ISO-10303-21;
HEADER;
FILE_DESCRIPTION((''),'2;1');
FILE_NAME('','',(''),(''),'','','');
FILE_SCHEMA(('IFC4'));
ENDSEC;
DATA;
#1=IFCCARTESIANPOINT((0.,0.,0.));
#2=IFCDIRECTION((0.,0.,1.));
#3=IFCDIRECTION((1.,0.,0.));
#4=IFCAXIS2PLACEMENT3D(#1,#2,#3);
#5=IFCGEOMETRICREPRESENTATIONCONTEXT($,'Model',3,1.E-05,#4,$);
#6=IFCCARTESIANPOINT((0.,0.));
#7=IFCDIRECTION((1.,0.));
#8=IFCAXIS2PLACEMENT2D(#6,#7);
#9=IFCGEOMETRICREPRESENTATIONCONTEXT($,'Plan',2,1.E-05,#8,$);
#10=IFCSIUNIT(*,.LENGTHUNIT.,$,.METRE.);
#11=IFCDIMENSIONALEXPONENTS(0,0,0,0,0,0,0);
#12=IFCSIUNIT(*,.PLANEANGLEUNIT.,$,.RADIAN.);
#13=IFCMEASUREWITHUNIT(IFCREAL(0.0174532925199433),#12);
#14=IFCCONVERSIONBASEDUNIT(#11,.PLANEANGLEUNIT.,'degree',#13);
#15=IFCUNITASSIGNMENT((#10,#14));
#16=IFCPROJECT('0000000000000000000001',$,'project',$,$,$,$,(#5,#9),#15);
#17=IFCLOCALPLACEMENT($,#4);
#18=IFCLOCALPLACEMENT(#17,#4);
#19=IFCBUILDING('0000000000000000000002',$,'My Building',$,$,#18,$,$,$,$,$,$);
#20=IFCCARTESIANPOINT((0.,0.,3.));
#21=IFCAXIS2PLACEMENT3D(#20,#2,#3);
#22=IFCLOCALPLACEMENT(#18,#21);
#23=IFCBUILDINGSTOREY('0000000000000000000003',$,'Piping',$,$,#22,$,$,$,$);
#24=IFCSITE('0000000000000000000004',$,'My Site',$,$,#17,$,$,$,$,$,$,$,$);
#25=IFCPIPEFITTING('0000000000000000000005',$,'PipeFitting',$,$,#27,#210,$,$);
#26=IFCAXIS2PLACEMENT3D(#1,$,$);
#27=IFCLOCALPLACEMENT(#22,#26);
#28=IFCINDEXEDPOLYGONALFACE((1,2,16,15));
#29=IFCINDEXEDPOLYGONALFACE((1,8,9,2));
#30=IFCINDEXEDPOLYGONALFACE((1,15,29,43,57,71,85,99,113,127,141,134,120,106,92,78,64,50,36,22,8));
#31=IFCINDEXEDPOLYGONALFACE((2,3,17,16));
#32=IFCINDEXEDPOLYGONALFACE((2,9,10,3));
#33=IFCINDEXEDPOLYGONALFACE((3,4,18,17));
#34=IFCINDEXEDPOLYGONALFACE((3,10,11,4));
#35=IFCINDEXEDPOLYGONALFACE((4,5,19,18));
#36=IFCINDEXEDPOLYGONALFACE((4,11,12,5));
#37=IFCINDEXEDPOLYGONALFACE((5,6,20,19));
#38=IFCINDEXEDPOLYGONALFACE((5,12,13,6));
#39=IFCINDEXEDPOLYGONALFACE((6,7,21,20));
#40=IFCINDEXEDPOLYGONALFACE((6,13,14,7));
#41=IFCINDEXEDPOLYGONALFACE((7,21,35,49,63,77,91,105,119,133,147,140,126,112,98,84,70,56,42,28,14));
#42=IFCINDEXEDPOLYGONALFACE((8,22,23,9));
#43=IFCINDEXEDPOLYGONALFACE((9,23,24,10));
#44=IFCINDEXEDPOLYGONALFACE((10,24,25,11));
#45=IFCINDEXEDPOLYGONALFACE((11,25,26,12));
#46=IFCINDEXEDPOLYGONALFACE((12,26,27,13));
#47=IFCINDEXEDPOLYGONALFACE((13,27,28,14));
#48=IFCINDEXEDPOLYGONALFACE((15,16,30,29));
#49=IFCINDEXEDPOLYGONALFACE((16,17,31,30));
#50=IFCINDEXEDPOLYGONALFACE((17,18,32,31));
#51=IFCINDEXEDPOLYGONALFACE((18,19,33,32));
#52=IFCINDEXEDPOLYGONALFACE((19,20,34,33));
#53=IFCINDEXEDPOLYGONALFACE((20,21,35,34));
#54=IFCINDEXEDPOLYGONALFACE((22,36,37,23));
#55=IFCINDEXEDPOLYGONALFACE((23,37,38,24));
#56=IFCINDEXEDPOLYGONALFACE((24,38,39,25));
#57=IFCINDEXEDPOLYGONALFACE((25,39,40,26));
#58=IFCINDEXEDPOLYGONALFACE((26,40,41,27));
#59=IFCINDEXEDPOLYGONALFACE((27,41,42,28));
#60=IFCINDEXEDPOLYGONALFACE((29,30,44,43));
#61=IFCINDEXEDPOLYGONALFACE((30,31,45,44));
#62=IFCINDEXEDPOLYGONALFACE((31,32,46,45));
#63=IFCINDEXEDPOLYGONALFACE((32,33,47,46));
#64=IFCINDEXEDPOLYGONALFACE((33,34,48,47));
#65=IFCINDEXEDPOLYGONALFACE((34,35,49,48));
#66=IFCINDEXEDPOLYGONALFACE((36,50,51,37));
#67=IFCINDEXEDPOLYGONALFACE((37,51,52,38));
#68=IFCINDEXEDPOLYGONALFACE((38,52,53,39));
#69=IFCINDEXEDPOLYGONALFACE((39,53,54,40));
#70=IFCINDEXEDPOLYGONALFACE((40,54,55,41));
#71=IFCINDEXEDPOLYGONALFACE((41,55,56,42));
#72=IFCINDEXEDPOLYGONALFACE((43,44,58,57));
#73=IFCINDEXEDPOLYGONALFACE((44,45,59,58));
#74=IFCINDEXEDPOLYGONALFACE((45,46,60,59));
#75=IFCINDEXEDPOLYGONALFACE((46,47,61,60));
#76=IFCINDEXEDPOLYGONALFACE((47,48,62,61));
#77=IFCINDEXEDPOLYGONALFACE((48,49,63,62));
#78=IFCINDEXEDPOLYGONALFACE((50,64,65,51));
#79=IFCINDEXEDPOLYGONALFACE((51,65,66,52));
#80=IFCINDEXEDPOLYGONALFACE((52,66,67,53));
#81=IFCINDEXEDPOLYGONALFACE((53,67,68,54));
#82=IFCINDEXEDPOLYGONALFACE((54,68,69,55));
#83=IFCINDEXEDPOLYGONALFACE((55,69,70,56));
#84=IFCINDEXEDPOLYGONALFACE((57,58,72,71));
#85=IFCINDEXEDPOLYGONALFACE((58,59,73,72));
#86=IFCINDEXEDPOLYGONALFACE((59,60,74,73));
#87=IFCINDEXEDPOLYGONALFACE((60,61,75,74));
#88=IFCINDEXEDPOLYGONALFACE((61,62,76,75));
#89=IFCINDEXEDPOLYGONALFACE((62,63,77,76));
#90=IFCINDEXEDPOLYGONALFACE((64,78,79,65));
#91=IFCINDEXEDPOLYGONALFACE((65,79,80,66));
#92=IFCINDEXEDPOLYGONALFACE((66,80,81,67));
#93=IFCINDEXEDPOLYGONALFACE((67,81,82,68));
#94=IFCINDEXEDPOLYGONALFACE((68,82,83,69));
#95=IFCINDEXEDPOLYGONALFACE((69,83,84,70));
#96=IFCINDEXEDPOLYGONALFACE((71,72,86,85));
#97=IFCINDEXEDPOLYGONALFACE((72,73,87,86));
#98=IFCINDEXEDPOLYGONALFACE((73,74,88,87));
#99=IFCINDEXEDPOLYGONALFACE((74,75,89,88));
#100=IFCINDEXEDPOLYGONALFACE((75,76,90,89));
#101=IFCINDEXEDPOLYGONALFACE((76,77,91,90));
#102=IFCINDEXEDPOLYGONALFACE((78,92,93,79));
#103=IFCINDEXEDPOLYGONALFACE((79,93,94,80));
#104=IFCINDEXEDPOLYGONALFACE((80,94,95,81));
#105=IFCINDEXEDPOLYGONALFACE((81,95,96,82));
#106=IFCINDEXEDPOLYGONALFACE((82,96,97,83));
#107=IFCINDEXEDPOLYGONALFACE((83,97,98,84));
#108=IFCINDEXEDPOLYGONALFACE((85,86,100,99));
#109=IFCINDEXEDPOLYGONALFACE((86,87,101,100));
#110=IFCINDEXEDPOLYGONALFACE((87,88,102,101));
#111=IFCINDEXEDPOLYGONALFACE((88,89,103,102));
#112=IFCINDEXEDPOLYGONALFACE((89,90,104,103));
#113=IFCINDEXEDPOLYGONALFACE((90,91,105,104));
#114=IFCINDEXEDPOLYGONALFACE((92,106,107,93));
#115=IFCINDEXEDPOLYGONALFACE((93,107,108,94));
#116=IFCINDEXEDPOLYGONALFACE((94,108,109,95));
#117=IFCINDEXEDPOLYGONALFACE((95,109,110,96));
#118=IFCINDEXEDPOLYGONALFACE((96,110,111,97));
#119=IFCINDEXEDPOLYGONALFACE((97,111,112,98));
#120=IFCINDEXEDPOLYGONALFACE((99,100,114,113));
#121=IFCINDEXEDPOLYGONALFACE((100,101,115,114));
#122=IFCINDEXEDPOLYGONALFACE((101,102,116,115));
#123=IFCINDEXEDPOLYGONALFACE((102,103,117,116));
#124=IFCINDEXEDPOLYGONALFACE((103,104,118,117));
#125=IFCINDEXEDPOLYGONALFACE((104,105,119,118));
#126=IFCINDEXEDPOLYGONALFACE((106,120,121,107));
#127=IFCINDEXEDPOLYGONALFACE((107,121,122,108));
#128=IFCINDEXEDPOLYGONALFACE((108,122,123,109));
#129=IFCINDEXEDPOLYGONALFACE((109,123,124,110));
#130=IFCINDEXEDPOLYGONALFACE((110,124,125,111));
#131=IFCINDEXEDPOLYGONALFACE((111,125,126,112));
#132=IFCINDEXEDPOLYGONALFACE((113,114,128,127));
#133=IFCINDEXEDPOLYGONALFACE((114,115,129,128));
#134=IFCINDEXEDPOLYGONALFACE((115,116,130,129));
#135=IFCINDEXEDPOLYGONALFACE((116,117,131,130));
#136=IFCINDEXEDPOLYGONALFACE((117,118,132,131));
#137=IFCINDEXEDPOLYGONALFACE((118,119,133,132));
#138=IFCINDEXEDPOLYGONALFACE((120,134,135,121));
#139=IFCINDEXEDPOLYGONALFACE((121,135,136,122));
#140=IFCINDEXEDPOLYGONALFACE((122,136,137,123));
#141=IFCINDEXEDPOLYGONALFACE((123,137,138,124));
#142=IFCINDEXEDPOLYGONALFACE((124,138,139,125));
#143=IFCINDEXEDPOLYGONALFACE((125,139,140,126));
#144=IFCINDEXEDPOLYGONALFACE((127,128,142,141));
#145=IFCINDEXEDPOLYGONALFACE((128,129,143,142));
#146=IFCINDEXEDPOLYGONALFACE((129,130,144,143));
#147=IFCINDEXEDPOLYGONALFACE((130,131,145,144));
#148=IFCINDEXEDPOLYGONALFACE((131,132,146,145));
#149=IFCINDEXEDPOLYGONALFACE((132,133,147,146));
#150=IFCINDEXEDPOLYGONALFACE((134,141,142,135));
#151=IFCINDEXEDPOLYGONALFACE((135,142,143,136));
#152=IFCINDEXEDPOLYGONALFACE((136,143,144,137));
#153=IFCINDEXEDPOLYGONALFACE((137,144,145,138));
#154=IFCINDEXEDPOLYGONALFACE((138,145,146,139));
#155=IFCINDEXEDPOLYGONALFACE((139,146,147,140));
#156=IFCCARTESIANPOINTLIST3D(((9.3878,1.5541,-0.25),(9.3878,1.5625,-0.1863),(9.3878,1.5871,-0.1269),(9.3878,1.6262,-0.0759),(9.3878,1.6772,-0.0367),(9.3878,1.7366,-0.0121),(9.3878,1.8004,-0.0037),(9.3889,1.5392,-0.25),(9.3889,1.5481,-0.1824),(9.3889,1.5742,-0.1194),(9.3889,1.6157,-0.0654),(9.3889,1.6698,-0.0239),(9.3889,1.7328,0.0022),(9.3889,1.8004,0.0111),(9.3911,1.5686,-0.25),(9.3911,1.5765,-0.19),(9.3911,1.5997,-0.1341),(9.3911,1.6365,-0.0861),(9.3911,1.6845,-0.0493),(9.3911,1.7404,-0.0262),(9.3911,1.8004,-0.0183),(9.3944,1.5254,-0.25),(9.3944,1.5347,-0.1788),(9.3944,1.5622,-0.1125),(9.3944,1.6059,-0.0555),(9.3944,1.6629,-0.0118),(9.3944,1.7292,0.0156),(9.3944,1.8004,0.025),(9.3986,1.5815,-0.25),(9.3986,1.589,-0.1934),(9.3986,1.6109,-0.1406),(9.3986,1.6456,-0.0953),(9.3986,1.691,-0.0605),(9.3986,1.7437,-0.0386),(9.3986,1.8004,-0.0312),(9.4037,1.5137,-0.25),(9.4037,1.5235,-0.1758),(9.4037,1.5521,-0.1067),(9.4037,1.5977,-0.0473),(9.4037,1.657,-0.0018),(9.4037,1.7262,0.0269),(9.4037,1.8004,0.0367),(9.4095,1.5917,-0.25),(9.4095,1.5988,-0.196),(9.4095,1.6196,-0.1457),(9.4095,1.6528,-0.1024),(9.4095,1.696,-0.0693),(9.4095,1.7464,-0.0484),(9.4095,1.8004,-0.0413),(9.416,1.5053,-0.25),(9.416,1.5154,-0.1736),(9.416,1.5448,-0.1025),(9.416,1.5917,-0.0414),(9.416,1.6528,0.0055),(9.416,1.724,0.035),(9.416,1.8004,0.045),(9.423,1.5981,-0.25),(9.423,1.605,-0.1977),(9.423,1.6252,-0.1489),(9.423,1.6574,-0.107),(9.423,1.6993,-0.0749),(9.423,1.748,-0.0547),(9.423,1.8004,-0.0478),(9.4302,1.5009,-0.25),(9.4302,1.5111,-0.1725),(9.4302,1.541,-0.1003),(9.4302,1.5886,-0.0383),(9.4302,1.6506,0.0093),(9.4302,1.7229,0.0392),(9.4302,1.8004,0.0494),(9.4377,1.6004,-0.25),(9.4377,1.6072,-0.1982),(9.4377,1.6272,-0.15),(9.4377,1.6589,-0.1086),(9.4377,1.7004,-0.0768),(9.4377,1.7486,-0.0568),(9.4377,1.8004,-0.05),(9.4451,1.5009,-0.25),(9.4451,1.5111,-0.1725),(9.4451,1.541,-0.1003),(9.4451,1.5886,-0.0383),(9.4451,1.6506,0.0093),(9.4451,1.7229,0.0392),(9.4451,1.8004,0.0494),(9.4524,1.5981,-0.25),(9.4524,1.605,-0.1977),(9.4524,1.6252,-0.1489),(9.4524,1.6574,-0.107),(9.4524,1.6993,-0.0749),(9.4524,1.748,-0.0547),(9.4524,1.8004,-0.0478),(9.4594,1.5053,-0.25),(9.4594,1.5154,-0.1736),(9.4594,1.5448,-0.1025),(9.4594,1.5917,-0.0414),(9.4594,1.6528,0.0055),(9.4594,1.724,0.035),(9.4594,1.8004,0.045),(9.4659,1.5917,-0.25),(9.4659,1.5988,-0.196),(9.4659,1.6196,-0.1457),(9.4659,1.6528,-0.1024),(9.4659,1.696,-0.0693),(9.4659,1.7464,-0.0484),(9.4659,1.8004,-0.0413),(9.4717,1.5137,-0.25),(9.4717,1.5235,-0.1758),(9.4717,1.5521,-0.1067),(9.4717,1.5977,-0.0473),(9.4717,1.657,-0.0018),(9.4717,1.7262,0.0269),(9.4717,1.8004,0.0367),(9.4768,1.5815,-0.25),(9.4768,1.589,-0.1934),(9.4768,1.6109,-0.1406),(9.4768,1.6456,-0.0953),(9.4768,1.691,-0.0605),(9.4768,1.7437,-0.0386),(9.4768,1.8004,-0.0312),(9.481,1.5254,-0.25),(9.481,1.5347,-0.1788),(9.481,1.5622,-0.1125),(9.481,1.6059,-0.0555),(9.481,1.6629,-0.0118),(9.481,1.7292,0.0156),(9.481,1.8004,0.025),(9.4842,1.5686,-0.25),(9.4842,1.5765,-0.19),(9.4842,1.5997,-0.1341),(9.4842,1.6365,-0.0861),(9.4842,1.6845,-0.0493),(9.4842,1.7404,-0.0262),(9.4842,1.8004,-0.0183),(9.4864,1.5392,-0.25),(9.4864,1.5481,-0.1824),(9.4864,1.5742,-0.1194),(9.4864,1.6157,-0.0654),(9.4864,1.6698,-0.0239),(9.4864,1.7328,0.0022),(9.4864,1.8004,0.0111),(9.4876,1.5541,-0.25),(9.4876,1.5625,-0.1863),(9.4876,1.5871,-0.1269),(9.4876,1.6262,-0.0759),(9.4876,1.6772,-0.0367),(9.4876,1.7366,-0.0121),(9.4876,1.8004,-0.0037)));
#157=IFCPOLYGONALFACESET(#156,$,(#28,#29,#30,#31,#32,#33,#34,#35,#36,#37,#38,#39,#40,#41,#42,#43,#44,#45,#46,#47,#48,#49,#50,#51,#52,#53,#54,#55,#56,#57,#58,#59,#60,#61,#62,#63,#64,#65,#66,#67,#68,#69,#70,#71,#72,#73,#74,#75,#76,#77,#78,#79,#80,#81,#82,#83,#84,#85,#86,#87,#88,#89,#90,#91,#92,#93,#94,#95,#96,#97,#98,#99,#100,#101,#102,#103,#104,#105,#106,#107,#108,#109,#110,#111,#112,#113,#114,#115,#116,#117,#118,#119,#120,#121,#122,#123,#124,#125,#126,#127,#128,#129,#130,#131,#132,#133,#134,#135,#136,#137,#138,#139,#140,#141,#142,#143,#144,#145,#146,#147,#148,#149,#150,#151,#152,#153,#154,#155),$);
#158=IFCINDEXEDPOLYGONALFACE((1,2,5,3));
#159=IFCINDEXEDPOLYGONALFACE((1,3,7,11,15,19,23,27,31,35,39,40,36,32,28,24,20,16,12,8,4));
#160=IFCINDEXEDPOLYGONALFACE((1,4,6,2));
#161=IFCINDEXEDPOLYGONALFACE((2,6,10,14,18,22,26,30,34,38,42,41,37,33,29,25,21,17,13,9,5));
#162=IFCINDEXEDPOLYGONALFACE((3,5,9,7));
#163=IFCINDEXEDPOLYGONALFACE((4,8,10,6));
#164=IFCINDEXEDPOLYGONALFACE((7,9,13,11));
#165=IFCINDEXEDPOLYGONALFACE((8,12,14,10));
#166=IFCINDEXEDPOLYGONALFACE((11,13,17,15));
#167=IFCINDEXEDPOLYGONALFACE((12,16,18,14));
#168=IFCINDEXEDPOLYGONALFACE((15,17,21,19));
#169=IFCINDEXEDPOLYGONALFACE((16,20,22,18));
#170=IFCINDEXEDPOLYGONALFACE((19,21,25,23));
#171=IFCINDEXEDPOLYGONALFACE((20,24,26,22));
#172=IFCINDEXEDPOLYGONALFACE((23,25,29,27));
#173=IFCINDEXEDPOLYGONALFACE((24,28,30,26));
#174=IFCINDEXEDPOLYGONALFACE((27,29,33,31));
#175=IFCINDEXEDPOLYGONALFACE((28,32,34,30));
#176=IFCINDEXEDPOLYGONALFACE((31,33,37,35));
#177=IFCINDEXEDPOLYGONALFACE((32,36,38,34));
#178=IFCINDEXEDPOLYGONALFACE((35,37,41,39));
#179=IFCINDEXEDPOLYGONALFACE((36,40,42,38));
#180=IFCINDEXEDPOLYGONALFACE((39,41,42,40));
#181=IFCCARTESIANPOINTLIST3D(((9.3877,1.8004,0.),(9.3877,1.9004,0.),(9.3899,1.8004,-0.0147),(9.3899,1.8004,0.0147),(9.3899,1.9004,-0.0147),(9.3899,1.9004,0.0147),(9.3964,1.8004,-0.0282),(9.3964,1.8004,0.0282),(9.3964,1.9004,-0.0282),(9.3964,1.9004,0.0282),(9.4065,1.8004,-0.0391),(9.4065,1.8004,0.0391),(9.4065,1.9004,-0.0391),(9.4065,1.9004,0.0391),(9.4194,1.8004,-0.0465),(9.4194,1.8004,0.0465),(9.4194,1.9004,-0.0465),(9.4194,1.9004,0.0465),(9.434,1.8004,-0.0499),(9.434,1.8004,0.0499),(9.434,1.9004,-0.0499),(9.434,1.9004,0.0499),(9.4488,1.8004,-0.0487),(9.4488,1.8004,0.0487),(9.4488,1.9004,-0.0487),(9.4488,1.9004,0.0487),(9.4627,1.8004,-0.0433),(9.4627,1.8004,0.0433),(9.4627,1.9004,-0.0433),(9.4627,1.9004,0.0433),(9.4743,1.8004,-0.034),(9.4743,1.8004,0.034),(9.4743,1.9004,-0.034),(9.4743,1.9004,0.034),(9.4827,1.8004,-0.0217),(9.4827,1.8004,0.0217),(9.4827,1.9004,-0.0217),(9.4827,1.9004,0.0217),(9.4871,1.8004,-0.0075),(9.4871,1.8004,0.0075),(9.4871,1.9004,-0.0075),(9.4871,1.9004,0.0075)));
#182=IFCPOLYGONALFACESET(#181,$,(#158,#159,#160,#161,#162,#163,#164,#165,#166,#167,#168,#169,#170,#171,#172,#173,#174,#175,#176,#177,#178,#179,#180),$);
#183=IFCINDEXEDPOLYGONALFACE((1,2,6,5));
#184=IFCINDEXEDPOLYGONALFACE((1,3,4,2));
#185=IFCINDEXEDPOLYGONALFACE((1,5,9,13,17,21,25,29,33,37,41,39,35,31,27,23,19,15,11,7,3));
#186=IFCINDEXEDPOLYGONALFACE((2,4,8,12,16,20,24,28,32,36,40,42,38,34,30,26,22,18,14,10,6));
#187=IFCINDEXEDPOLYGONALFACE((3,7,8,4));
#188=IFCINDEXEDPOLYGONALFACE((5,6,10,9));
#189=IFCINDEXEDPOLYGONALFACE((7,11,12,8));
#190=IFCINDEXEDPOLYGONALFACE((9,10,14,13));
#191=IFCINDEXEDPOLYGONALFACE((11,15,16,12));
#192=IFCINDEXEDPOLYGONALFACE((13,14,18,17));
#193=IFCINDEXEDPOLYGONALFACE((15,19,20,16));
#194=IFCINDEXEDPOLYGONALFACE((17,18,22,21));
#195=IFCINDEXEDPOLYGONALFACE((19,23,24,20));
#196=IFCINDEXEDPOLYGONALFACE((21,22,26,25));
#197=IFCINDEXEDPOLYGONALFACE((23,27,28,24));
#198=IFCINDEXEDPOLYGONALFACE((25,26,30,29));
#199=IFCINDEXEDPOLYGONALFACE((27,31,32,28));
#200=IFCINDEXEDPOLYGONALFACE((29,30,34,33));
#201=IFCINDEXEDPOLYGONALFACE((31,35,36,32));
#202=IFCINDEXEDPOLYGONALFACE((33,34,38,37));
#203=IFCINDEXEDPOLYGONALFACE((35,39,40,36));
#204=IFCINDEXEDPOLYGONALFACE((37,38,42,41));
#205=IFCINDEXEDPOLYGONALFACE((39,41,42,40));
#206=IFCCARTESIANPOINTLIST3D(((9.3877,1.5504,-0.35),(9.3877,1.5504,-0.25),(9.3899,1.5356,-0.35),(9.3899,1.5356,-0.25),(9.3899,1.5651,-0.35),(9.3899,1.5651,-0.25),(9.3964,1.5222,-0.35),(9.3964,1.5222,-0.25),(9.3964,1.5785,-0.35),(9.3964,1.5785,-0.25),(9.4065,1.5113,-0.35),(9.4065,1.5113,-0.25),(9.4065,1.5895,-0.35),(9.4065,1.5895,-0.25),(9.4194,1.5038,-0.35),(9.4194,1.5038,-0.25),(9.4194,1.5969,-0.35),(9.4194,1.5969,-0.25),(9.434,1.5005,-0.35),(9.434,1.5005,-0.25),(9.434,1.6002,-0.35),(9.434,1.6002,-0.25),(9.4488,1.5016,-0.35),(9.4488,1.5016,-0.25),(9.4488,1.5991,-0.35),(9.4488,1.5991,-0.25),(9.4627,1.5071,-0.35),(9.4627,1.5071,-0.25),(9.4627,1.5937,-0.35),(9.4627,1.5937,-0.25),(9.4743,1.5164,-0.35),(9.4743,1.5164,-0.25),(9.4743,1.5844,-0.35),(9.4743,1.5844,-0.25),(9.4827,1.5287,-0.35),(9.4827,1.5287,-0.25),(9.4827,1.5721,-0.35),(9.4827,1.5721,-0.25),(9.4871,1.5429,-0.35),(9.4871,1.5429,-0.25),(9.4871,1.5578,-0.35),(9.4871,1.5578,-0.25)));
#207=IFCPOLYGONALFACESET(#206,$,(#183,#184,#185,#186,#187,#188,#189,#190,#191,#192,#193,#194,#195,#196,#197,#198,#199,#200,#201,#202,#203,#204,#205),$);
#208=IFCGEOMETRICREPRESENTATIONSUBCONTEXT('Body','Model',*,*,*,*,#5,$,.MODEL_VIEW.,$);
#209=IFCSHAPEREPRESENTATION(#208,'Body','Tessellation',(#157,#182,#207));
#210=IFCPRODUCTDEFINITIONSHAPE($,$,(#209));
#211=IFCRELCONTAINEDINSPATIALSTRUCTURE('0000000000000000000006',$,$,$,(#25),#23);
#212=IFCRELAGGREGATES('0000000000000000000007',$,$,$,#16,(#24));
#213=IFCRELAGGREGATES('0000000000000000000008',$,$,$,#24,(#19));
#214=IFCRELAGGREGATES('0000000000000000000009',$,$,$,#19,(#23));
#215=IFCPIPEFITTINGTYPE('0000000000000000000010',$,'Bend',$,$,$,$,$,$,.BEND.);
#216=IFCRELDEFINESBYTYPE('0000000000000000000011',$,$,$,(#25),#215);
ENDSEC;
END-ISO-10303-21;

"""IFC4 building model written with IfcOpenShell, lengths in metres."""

from ifc_helpers import new_model, entity, si_unit, converted_unit, frame, origin_with_axes, origin_2d_with_axis, place, context, subcontext, project, spatial, circle, extrude, source, transform, mapped, type_object, type_shapes, element, save


model = new_model("IFC4")

# Units and contexts
model_context = context("Model", 3, precision=1e-05, world=origin_with_axes())
plan_context = context("Plan", 2, precision=1e-05, world=origin_2d_with_axis())
body_context = subcontext(model_context, "Body", "Model", "MODEL_VIEW")
ifc_project = project(units=[si_unit("LENGTHUNIT", "METRE"), converted_unit("PLANEANGLEUNIT", "degree", entity("IfcReal", 0.0174532925199433), si_unit("PLANEANGLEUNIT", "RADIAN"), dimensions=[0, 0, 0, 0, 0, 0, 0])], contexts=[model_context, plan_context])

# Site, building, storey
site_placement = place(None, origin_with_axes())
site = spatial("IfcSite", under=ifc_project, at=site_placement, Name="My Site")
building_placement = place(site_placement, origin_with_axes())
building = spatial("IfcBuilding", under=site, at=building_placement, Name="My Building")
storey_placement = place(building_placement, frame((0.0, 0.0, 3.0), z_axis=(0.0, 0.0, 1.0), x_axis=(1.0, 0.0, 0.0)))
storey = spatial("IfcBuildingStorey", under=building, at=storey_placement, Name="Piping")

# Pipe fitting
pipe_fitting_type = type_object("IfcPipeFittingType", Name="Bend", PredefinedType="BEND")
shared_shape = source(origin_with_axes(), body_context, "Body", "SolidModel", [
    entity("IfcSweptDiskSolid", entity("IfcIndexedPolyCurve", entity("IfcCartesianPointList3D", [[0.0, 0.0, -0.1], [0.0, -0.0732, -0.2768], [0.0, -0.25, -0.35]]), [entity("IfcArcIndex", [1, 2, 3])]), 0.05),
    extrude(circle(Radius=0.05), origin_with_axes(), (0.0, 0.0, -1.0), 0.1),
    extrude(circle(Radius=0.05), frame((0.0, -0.25, -0.35), z_axis=(0.0, -1.0, 0.0), x_axis=(1.0, 0.0, 0.0)), (0.0, 0.0, 1.0), 0.1),
])
type_shapes(pipe_fitting_type, [shared_shape])
for number, where, z_axis, x_axis, name in (
    (1, (9.4377, 1.9004, 0.0), (0.0, 1.0, 0.0), (-1.0, 0.0, 0.0), "PipeFitting"),
):
    element("IfcPipeFitting", number, at=place(storey_placement, frame(where, z_axis=z_axis, x_axis=x_axis)), inside=storey, type_object=pipe_fitting_type, Name=name, context=body_context, shape_type="MappedRepresentation", body=[
        mapped(shared_shape, transform((0.0, 0.0, 0.0), x_axis=(1.0, 0.0, 0.0), y_axis=(0.0, 1.0, 0.0), z_axis=(0.0, 0.0, 1.0), scale=1.0)),
    ])

save(model, "model.ifc")
